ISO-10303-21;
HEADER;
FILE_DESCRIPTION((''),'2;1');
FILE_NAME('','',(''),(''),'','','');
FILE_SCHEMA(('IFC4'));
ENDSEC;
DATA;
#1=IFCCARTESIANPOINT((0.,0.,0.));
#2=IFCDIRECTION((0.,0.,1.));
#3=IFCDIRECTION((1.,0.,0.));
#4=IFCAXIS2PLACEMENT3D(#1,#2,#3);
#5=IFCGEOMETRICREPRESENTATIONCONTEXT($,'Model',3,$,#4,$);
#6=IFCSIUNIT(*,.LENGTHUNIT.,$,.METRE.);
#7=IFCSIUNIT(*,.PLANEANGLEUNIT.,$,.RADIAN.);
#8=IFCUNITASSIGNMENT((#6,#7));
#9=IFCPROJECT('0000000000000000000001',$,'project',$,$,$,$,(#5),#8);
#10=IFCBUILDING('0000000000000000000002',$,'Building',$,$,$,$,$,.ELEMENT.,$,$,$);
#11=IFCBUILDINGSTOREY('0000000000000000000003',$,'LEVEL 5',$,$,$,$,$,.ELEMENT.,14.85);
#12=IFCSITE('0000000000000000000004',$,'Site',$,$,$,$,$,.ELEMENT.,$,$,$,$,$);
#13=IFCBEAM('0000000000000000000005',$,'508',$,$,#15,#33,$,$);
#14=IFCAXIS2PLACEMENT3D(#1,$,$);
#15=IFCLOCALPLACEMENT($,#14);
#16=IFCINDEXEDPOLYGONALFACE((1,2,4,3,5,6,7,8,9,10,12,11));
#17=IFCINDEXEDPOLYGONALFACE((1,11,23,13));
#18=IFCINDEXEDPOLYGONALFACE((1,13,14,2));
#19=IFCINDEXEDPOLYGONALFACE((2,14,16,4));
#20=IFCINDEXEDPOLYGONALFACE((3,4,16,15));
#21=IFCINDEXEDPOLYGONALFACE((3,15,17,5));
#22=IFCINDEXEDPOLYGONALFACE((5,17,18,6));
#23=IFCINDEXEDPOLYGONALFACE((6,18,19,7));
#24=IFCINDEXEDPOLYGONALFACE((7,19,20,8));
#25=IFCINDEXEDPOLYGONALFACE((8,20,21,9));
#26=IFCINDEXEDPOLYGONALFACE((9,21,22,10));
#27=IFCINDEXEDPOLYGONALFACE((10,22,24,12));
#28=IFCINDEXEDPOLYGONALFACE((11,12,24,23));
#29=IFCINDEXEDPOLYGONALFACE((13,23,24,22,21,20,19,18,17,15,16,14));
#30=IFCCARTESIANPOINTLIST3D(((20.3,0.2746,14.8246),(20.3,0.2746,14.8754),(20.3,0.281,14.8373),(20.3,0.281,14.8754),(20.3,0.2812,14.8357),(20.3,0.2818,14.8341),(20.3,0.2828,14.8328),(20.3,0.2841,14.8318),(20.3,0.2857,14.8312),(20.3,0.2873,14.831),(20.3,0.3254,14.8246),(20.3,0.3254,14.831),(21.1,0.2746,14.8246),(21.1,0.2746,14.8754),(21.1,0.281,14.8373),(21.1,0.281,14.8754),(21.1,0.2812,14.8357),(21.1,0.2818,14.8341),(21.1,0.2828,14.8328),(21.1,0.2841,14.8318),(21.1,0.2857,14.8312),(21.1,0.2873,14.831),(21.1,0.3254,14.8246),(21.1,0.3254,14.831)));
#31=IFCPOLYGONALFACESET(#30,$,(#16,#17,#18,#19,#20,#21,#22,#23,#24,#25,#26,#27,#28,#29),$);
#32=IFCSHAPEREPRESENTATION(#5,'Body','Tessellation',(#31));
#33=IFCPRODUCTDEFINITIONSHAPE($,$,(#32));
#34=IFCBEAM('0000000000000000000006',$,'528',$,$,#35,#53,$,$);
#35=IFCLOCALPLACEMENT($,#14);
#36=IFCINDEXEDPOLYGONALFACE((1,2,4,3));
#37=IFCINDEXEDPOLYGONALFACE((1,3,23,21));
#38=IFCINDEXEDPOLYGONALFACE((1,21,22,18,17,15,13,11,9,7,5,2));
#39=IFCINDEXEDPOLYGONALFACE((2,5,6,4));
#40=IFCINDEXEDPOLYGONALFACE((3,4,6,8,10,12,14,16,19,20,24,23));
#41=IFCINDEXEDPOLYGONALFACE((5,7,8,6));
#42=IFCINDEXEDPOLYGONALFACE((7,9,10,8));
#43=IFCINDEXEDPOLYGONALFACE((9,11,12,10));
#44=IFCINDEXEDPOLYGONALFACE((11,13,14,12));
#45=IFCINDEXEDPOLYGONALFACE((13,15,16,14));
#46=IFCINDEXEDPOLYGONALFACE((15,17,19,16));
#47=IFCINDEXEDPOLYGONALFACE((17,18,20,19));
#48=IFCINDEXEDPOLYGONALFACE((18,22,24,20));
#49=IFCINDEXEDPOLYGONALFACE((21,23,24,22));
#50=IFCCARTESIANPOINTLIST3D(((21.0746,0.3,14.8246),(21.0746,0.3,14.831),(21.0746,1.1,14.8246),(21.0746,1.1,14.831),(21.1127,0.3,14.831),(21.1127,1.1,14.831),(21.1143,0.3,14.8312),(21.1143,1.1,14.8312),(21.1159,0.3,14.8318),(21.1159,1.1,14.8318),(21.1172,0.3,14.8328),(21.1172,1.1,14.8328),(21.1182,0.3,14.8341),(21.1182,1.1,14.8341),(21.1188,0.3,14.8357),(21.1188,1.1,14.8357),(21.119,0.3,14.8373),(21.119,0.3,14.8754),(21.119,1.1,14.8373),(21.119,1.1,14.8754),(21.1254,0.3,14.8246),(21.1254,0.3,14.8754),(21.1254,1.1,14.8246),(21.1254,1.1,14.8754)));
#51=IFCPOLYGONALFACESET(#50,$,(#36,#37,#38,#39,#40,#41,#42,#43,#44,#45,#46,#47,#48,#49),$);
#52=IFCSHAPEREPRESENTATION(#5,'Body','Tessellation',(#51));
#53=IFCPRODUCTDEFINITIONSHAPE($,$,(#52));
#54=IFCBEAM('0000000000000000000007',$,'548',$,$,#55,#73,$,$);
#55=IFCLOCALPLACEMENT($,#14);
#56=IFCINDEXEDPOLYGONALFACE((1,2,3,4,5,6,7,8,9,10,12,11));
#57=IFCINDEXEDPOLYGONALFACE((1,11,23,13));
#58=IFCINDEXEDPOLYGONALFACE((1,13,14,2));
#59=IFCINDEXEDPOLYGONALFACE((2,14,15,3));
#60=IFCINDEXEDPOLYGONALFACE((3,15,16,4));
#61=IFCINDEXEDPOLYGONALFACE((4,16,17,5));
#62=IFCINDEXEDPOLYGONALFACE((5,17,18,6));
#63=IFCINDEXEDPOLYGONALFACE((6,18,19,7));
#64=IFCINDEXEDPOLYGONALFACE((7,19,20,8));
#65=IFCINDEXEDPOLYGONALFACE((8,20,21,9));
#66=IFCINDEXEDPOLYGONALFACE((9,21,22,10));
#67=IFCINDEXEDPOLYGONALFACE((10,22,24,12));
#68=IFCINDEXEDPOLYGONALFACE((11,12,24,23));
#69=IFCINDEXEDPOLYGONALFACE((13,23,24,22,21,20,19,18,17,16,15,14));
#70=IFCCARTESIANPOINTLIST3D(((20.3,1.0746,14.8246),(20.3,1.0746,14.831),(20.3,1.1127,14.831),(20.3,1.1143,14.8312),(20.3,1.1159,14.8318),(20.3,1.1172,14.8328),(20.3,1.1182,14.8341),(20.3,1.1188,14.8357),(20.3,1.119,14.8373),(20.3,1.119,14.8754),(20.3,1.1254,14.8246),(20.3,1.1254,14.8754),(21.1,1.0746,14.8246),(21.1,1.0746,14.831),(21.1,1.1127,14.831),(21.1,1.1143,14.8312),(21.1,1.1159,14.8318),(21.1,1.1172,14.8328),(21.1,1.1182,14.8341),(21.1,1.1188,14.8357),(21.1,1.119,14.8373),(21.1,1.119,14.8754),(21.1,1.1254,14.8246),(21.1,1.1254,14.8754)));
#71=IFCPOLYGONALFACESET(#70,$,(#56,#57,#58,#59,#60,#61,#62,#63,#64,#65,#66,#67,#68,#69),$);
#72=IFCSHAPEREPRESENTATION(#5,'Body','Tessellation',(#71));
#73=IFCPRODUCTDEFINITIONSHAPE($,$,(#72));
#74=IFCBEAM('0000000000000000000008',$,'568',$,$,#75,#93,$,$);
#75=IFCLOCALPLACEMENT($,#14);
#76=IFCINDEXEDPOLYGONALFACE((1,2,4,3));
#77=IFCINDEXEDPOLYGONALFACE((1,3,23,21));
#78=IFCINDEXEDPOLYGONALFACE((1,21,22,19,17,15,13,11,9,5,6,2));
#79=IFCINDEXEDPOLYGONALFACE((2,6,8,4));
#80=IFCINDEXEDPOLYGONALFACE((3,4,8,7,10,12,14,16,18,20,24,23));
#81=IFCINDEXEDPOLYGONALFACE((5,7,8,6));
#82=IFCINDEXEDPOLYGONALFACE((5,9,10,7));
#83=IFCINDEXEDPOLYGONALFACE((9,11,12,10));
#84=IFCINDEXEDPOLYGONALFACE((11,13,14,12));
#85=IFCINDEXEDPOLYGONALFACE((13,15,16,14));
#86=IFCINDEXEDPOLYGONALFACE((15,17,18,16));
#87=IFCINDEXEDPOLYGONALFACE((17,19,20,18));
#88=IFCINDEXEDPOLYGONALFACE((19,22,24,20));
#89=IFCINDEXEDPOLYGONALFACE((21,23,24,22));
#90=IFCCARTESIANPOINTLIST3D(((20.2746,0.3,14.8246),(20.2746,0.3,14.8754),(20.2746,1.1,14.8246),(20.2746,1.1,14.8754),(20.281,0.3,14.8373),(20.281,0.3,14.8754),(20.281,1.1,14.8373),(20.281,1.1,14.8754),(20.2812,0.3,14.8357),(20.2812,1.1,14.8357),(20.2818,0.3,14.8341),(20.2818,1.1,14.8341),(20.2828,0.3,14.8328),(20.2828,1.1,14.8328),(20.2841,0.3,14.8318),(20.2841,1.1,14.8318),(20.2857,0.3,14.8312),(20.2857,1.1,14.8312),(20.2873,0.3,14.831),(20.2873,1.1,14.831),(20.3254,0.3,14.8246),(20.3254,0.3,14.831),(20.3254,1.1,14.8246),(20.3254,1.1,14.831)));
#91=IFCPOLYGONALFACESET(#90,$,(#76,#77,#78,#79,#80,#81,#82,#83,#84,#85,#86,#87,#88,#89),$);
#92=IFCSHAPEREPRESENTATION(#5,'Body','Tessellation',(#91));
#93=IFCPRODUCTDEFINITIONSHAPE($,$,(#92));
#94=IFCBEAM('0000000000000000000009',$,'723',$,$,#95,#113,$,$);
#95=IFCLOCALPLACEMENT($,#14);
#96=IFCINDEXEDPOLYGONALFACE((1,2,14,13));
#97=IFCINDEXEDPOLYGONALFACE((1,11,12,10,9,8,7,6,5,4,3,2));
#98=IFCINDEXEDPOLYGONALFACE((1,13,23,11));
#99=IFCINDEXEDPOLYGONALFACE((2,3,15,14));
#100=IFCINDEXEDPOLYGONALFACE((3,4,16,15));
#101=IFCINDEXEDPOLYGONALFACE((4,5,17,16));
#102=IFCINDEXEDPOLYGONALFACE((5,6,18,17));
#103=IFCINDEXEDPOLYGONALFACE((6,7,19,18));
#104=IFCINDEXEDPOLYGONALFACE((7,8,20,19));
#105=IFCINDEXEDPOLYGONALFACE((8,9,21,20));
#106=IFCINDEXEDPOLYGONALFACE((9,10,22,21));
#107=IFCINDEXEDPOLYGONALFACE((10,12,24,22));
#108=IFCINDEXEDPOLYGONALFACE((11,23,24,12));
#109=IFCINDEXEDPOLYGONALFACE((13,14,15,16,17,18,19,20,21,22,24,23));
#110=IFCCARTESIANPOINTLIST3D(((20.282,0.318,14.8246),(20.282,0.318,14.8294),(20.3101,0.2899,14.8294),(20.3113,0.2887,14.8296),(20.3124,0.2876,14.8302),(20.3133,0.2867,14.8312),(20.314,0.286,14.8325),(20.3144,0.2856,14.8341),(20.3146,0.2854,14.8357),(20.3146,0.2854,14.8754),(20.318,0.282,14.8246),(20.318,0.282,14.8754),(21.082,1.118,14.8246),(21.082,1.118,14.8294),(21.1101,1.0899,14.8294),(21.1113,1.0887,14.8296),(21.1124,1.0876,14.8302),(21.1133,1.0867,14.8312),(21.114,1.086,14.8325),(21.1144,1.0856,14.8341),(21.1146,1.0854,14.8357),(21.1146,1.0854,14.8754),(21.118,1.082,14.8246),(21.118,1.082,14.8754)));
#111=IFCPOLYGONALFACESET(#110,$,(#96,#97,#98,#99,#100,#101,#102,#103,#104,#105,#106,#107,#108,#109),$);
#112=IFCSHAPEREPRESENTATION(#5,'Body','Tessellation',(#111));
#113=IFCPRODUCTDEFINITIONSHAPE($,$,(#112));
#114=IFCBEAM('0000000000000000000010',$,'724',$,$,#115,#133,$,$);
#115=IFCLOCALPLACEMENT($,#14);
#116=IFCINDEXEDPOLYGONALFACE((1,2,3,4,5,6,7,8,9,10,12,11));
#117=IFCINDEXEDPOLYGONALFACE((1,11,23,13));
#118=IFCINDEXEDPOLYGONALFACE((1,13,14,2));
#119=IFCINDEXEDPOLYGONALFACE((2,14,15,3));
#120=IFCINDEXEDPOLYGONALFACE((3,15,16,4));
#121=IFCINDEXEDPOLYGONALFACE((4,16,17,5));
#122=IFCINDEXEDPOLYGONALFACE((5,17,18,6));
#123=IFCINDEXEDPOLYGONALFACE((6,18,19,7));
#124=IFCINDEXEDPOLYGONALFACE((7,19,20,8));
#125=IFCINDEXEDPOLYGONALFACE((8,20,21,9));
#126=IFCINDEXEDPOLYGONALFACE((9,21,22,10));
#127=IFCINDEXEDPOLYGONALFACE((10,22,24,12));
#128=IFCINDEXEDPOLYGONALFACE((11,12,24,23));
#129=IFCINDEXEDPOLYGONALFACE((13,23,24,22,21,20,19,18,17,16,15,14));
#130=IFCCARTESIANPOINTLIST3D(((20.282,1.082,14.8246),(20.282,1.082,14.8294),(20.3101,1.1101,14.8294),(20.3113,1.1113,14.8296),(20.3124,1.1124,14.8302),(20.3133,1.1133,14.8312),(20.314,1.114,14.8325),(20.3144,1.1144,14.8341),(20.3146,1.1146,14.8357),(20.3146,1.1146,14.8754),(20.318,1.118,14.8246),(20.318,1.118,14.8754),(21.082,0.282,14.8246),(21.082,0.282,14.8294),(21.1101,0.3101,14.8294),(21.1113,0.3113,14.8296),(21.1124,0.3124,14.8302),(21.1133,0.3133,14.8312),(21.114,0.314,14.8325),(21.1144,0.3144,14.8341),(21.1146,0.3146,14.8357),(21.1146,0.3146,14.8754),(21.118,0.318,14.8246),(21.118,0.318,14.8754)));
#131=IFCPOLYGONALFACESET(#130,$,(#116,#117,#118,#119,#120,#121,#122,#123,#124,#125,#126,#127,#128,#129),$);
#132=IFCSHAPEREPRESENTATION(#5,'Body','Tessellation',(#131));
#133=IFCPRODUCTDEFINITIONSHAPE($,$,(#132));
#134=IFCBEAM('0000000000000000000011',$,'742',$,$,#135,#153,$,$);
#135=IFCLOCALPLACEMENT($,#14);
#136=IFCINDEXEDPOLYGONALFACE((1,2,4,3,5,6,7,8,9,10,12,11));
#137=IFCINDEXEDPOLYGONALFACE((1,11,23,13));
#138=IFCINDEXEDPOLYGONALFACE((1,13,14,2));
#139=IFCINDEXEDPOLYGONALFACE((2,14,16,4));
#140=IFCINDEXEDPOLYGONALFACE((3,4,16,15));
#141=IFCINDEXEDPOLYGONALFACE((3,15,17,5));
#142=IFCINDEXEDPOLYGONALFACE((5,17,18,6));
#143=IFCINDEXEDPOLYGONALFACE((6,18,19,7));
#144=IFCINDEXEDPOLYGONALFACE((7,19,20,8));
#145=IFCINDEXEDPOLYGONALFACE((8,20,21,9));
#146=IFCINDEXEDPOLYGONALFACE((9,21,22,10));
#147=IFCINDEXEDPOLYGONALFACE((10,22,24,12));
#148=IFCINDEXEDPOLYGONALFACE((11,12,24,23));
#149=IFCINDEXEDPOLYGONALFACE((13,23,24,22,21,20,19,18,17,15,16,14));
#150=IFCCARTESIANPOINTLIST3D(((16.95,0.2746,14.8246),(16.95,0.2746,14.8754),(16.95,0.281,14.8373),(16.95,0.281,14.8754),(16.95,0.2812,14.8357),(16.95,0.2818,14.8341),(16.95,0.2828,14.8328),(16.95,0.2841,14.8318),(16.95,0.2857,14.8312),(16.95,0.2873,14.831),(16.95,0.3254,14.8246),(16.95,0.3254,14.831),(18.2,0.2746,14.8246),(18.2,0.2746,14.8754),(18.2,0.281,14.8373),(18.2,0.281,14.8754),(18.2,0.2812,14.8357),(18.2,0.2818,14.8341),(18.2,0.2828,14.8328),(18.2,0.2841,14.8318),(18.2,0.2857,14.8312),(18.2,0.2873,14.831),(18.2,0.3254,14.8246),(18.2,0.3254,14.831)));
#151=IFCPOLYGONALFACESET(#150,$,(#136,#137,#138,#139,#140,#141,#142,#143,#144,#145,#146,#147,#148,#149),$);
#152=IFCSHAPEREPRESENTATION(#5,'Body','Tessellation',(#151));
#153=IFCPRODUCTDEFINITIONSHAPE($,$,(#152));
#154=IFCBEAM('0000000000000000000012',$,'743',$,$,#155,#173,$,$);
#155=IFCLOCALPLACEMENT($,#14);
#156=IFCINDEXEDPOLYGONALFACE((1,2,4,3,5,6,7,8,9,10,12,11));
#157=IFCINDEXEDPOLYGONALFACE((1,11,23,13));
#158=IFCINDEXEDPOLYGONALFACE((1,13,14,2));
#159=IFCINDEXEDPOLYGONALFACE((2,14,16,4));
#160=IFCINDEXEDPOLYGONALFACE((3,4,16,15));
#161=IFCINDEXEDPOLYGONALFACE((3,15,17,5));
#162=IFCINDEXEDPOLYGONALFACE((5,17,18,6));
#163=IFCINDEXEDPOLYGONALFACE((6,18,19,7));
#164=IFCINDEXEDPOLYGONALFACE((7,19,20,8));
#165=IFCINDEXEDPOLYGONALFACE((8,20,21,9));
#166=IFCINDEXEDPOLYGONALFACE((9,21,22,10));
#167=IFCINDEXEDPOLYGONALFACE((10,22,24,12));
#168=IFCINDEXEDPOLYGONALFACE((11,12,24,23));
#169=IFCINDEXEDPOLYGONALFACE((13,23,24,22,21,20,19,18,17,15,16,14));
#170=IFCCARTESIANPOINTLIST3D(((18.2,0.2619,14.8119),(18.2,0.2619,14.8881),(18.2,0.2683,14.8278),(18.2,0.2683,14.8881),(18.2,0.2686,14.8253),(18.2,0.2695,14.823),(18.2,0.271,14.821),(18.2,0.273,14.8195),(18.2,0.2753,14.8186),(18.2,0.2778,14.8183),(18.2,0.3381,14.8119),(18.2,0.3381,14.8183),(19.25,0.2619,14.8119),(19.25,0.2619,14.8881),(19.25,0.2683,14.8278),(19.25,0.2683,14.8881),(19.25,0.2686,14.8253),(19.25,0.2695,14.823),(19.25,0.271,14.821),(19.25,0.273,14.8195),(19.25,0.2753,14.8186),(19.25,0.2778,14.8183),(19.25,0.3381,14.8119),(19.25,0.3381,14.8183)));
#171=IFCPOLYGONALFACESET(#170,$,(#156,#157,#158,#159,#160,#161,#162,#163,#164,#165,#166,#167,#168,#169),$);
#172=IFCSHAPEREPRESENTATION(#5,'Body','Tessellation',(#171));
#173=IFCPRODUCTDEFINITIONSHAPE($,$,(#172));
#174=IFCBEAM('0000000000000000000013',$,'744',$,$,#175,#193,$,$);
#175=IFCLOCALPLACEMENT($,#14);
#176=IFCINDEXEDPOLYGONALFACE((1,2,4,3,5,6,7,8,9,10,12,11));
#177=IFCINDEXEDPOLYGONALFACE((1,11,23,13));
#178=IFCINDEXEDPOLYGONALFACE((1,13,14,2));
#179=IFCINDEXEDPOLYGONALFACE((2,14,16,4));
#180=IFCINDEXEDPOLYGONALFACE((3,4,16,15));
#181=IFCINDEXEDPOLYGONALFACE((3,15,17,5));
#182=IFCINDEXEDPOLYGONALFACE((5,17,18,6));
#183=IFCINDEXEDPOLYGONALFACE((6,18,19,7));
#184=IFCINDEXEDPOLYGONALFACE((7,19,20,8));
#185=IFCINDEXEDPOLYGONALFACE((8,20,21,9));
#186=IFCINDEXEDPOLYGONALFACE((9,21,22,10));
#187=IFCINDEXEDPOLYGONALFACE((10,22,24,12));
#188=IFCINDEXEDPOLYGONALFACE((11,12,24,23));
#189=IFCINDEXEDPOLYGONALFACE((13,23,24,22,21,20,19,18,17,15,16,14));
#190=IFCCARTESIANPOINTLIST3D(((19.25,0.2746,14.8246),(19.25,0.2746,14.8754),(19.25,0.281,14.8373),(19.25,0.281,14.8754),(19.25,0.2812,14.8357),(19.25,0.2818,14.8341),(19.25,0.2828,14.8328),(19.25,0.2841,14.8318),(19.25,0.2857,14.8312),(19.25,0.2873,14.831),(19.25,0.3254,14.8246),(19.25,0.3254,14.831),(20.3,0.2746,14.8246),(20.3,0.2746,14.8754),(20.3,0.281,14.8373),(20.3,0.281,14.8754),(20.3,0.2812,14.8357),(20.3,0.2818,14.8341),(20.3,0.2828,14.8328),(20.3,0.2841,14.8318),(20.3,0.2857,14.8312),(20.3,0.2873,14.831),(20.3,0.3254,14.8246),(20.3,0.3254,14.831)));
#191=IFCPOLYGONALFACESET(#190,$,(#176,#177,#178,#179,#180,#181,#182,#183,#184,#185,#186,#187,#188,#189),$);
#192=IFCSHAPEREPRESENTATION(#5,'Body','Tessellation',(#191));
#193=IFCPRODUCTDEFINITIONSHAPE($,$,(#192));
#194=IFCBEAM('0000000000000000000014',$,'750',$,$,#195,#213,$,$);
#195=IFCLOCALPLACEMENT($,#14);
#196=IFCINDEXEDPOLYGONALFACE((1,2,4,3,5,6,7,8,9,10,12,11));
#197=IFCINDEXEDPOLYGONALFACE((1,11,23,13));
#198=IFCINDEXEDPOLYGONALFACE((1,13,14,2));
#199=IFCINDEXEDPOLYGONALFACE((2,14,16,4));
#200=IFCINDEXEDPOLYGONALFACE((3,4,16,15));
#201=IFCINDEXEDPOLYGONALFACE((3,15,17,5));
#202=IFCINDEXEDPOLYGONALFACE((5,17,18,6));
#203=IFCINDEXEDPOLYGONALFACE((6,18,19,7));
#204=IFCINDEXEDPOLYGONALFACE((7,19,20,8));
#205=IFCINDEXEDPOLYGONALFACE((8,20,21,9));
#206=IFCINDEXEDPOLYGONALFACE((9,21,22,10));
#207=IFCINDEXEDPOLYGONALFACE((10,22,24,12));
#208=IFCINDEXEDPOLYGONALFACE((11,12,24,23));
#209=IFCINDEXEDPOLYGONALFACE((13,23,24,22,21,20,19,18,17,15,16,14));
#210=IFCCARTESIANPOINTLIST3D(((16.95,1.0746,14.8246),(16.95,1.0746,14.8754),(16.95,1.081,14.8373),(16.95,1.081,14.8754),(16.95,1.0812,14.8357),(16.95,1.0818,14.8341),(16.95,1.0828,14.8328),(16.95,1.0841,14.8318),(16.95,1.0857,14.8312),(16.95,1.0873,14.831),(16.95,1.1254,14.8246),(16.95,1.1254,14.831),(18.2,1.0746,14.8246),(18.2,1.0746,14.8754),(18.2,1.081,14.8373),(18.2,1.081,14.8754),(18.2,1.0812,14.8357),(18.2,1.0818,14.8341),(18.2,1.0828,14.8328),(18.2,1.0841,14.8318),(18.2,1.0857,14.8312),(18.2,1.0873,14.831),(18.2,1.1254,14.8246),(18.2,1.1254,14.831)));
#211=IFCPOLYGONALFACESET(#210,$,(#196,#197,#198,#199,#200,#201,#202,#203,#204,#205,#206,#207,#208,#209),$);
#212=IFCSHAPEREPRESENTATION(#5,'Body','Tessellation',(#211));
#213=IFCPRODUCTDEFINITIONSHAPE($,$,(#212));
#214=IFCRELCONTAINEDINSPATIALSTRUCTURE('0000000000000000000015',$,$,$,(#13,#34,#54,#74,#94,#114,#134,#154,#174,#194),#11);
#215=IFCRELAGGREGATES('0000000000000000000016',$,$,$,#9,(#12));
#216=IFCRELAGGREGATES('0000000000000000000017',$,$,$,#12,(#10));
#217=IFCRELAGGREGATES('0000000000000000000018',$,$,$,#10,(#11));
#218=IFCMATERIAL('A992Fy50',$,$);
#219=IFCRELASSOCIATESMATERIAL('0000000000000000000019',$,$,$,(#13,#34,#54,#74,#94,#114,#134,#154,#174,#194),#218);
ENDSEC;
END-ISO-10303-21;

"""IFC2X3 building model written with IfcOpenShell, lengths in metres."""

from ifc_helpers import new_model, si_unit, frame, origin_with_axes, origin_2d_with_axis, place, context, project, spatial, l_section, extrude, material, element, save


model = new_model("IFC2X3")

# Units and contexts
model_context = context("Model", 3, world=origin_with_axes())
ifc_project = project(units=[si_unit("LENGTHUNIT", "METRE"), si_unit("PLANEANGLEUNIT", "RADIAN")], contexts=[model_context])

# Site, building, storey
site = spatial("IfcSite", under=ifc_project, Name="Site", CompositionType="ELEMENT")
building = spatial("IfcBuilding", under=site, Name="Building", CompositionType="ELEMENT")
storey = spatial("IfcBuildingStorey", under=building, Name="LEVEL 5", CompositionType="ELEMENT", Elevation=14.85)

# Beams
ifc_material = material(Name="A992Fy50")
for number, where, z_axis, x_axis, name in (
    (1, (20.3, 0.3, 14.85), (1.0, 0.0, 0.0), (0.0, 1.0, 0.0), "508"),
    (2, (21.1, 0.3, 14.85), (0.0, 1.0, 0.0), (-1.0, 0.0, 0.0), "528"),
    (3, (21.1, 1.1, 14.85), (-1.0, 0.0, 0.0), (0.0, -1.0, 0.0), "548"),
    (4, (20.3, 1.1, 14.85), (0.0, -1.0, 0.0), (1.0, 0.0, 0.0), "568"),
):
    element("IfcBeam", number, at=place(None, frame(where, z_axis=z_axis, x_axis=x_axis)), inside=storey, material=ifc_material, Name=name, context=model_context, shape_type="SweptSolid", body=[
        extrude(l_section(Depth=0.0508, Width=0.0508, Thickness=0.0063, FilletRadius=0.0063, at=origin_2d_with_axis()), origin_with_axes(), (0.0, 0.0, 1.0), 0.8),
    ])
for number, where, z_axis, x_axis, name in (
    (5, (20.3, 0.3, 14.85), (0.707107, 0.707107, 0.0), (-0.707107, 0.707107, 0.0), "723"),
    (6, (21.1, 0.3, 14.85), (-0.707107, 0.707107, 0.0), (-0.707107, -0.707107, 0.0), "724"),
):
    element("IfcBeam", number, at=place(None, frame(where, z_axis=z_axis, x_axis=x_axis)), inside=storey, material=ifc_material, Name=name, context=model_context, shape_type="SweptSolid", body=[
        extrude(l_section(Depth=0.0508, Width=0.0508, Thickness=0.0048, FilletRadius=0.0063, at=origin_2d_with_axis()), origin_with_axes(), (0.0, 0.0, 1.0), 1.1314),
    ])
beam_1_placement = place(None, frame((16.95, 0.3, 14.85), z_axis=(1.0, 0.0, 0.0), x_axis=(0.0, 1.0, 0.0)))
element("IfcBeam", 7, at=beam_1_placement, inside=storey, material=ifc_material, Name="742", context=model_context, shape_type="SweptSolid", body=[
    extrude(l_section(Depth=0.0508, Width=0.0508, Thickness=0.0063, FilletRadius=0.0063, at=origin_2d_with_axis()), origin_with_axes(), (0.0, 0.0, 1.0), 1.25),
])
beam_2_placement = place(None, frame((18.2, 0.3, 14.85), z_axis=(1.0, 0.0, 0.0), x_axis=(0.0, 1.0, 0.0)))
element("IfcBeam", 8, at=beam_2_placement, inside=storey, material=ifc_material, Name="743", context=model_context, shape_type="SweptSolid", body=[
    extrude(l_section(Depth=0.0762, Width=0.0762, Thickness=0.0063, FilletRadius=0.0095, at=origin_2d_with_axis()), origin_with_axes(), (0.0, 0.0, 1.0), 1.05),
])
beam_3_placement = place(None, frame((19.25, 0.3, 14.85), z_axis=(1.0, 0.0, 0.0), x_axis=(0.0, 1.0, 0.0)))
element("IfcBeam", 9, at=beam_3_placement, inside=storey, material=ifc_material, Name="744", context=model_context, shape_type="SweptSolid", body=[
    extrude(l_section(Depth=0.0508, Width=0.0508, Thickness=0.0063, FilletRadius=0.0063, at=origin_2d_with_axis()), origin_with_axes(), (0.0, 0.0, 1.0), 1.05),
])
beam_4_placement = place(None, frame((16.95, 1.1, 14.85), z_axis=(1.0, 0.0, 0.0), x_axis=(0.0, 1.0, 0.0)))
element("IfcBeam", 10, at=beam_4_placement, inside=storey, material=ifc_material, Name="750", context=model_context, shape_type="SweptSolid", body=[
    extrude(l_section(Depth=0.0508, Width=0.0508, Thickness=0.0063, FilletRadius=0.0063, at=origin_2d_with_axis()), origin_with_axes(), (0.0, 0.0, 1.0), 1.25),
])

save(model, "model.ifc")
